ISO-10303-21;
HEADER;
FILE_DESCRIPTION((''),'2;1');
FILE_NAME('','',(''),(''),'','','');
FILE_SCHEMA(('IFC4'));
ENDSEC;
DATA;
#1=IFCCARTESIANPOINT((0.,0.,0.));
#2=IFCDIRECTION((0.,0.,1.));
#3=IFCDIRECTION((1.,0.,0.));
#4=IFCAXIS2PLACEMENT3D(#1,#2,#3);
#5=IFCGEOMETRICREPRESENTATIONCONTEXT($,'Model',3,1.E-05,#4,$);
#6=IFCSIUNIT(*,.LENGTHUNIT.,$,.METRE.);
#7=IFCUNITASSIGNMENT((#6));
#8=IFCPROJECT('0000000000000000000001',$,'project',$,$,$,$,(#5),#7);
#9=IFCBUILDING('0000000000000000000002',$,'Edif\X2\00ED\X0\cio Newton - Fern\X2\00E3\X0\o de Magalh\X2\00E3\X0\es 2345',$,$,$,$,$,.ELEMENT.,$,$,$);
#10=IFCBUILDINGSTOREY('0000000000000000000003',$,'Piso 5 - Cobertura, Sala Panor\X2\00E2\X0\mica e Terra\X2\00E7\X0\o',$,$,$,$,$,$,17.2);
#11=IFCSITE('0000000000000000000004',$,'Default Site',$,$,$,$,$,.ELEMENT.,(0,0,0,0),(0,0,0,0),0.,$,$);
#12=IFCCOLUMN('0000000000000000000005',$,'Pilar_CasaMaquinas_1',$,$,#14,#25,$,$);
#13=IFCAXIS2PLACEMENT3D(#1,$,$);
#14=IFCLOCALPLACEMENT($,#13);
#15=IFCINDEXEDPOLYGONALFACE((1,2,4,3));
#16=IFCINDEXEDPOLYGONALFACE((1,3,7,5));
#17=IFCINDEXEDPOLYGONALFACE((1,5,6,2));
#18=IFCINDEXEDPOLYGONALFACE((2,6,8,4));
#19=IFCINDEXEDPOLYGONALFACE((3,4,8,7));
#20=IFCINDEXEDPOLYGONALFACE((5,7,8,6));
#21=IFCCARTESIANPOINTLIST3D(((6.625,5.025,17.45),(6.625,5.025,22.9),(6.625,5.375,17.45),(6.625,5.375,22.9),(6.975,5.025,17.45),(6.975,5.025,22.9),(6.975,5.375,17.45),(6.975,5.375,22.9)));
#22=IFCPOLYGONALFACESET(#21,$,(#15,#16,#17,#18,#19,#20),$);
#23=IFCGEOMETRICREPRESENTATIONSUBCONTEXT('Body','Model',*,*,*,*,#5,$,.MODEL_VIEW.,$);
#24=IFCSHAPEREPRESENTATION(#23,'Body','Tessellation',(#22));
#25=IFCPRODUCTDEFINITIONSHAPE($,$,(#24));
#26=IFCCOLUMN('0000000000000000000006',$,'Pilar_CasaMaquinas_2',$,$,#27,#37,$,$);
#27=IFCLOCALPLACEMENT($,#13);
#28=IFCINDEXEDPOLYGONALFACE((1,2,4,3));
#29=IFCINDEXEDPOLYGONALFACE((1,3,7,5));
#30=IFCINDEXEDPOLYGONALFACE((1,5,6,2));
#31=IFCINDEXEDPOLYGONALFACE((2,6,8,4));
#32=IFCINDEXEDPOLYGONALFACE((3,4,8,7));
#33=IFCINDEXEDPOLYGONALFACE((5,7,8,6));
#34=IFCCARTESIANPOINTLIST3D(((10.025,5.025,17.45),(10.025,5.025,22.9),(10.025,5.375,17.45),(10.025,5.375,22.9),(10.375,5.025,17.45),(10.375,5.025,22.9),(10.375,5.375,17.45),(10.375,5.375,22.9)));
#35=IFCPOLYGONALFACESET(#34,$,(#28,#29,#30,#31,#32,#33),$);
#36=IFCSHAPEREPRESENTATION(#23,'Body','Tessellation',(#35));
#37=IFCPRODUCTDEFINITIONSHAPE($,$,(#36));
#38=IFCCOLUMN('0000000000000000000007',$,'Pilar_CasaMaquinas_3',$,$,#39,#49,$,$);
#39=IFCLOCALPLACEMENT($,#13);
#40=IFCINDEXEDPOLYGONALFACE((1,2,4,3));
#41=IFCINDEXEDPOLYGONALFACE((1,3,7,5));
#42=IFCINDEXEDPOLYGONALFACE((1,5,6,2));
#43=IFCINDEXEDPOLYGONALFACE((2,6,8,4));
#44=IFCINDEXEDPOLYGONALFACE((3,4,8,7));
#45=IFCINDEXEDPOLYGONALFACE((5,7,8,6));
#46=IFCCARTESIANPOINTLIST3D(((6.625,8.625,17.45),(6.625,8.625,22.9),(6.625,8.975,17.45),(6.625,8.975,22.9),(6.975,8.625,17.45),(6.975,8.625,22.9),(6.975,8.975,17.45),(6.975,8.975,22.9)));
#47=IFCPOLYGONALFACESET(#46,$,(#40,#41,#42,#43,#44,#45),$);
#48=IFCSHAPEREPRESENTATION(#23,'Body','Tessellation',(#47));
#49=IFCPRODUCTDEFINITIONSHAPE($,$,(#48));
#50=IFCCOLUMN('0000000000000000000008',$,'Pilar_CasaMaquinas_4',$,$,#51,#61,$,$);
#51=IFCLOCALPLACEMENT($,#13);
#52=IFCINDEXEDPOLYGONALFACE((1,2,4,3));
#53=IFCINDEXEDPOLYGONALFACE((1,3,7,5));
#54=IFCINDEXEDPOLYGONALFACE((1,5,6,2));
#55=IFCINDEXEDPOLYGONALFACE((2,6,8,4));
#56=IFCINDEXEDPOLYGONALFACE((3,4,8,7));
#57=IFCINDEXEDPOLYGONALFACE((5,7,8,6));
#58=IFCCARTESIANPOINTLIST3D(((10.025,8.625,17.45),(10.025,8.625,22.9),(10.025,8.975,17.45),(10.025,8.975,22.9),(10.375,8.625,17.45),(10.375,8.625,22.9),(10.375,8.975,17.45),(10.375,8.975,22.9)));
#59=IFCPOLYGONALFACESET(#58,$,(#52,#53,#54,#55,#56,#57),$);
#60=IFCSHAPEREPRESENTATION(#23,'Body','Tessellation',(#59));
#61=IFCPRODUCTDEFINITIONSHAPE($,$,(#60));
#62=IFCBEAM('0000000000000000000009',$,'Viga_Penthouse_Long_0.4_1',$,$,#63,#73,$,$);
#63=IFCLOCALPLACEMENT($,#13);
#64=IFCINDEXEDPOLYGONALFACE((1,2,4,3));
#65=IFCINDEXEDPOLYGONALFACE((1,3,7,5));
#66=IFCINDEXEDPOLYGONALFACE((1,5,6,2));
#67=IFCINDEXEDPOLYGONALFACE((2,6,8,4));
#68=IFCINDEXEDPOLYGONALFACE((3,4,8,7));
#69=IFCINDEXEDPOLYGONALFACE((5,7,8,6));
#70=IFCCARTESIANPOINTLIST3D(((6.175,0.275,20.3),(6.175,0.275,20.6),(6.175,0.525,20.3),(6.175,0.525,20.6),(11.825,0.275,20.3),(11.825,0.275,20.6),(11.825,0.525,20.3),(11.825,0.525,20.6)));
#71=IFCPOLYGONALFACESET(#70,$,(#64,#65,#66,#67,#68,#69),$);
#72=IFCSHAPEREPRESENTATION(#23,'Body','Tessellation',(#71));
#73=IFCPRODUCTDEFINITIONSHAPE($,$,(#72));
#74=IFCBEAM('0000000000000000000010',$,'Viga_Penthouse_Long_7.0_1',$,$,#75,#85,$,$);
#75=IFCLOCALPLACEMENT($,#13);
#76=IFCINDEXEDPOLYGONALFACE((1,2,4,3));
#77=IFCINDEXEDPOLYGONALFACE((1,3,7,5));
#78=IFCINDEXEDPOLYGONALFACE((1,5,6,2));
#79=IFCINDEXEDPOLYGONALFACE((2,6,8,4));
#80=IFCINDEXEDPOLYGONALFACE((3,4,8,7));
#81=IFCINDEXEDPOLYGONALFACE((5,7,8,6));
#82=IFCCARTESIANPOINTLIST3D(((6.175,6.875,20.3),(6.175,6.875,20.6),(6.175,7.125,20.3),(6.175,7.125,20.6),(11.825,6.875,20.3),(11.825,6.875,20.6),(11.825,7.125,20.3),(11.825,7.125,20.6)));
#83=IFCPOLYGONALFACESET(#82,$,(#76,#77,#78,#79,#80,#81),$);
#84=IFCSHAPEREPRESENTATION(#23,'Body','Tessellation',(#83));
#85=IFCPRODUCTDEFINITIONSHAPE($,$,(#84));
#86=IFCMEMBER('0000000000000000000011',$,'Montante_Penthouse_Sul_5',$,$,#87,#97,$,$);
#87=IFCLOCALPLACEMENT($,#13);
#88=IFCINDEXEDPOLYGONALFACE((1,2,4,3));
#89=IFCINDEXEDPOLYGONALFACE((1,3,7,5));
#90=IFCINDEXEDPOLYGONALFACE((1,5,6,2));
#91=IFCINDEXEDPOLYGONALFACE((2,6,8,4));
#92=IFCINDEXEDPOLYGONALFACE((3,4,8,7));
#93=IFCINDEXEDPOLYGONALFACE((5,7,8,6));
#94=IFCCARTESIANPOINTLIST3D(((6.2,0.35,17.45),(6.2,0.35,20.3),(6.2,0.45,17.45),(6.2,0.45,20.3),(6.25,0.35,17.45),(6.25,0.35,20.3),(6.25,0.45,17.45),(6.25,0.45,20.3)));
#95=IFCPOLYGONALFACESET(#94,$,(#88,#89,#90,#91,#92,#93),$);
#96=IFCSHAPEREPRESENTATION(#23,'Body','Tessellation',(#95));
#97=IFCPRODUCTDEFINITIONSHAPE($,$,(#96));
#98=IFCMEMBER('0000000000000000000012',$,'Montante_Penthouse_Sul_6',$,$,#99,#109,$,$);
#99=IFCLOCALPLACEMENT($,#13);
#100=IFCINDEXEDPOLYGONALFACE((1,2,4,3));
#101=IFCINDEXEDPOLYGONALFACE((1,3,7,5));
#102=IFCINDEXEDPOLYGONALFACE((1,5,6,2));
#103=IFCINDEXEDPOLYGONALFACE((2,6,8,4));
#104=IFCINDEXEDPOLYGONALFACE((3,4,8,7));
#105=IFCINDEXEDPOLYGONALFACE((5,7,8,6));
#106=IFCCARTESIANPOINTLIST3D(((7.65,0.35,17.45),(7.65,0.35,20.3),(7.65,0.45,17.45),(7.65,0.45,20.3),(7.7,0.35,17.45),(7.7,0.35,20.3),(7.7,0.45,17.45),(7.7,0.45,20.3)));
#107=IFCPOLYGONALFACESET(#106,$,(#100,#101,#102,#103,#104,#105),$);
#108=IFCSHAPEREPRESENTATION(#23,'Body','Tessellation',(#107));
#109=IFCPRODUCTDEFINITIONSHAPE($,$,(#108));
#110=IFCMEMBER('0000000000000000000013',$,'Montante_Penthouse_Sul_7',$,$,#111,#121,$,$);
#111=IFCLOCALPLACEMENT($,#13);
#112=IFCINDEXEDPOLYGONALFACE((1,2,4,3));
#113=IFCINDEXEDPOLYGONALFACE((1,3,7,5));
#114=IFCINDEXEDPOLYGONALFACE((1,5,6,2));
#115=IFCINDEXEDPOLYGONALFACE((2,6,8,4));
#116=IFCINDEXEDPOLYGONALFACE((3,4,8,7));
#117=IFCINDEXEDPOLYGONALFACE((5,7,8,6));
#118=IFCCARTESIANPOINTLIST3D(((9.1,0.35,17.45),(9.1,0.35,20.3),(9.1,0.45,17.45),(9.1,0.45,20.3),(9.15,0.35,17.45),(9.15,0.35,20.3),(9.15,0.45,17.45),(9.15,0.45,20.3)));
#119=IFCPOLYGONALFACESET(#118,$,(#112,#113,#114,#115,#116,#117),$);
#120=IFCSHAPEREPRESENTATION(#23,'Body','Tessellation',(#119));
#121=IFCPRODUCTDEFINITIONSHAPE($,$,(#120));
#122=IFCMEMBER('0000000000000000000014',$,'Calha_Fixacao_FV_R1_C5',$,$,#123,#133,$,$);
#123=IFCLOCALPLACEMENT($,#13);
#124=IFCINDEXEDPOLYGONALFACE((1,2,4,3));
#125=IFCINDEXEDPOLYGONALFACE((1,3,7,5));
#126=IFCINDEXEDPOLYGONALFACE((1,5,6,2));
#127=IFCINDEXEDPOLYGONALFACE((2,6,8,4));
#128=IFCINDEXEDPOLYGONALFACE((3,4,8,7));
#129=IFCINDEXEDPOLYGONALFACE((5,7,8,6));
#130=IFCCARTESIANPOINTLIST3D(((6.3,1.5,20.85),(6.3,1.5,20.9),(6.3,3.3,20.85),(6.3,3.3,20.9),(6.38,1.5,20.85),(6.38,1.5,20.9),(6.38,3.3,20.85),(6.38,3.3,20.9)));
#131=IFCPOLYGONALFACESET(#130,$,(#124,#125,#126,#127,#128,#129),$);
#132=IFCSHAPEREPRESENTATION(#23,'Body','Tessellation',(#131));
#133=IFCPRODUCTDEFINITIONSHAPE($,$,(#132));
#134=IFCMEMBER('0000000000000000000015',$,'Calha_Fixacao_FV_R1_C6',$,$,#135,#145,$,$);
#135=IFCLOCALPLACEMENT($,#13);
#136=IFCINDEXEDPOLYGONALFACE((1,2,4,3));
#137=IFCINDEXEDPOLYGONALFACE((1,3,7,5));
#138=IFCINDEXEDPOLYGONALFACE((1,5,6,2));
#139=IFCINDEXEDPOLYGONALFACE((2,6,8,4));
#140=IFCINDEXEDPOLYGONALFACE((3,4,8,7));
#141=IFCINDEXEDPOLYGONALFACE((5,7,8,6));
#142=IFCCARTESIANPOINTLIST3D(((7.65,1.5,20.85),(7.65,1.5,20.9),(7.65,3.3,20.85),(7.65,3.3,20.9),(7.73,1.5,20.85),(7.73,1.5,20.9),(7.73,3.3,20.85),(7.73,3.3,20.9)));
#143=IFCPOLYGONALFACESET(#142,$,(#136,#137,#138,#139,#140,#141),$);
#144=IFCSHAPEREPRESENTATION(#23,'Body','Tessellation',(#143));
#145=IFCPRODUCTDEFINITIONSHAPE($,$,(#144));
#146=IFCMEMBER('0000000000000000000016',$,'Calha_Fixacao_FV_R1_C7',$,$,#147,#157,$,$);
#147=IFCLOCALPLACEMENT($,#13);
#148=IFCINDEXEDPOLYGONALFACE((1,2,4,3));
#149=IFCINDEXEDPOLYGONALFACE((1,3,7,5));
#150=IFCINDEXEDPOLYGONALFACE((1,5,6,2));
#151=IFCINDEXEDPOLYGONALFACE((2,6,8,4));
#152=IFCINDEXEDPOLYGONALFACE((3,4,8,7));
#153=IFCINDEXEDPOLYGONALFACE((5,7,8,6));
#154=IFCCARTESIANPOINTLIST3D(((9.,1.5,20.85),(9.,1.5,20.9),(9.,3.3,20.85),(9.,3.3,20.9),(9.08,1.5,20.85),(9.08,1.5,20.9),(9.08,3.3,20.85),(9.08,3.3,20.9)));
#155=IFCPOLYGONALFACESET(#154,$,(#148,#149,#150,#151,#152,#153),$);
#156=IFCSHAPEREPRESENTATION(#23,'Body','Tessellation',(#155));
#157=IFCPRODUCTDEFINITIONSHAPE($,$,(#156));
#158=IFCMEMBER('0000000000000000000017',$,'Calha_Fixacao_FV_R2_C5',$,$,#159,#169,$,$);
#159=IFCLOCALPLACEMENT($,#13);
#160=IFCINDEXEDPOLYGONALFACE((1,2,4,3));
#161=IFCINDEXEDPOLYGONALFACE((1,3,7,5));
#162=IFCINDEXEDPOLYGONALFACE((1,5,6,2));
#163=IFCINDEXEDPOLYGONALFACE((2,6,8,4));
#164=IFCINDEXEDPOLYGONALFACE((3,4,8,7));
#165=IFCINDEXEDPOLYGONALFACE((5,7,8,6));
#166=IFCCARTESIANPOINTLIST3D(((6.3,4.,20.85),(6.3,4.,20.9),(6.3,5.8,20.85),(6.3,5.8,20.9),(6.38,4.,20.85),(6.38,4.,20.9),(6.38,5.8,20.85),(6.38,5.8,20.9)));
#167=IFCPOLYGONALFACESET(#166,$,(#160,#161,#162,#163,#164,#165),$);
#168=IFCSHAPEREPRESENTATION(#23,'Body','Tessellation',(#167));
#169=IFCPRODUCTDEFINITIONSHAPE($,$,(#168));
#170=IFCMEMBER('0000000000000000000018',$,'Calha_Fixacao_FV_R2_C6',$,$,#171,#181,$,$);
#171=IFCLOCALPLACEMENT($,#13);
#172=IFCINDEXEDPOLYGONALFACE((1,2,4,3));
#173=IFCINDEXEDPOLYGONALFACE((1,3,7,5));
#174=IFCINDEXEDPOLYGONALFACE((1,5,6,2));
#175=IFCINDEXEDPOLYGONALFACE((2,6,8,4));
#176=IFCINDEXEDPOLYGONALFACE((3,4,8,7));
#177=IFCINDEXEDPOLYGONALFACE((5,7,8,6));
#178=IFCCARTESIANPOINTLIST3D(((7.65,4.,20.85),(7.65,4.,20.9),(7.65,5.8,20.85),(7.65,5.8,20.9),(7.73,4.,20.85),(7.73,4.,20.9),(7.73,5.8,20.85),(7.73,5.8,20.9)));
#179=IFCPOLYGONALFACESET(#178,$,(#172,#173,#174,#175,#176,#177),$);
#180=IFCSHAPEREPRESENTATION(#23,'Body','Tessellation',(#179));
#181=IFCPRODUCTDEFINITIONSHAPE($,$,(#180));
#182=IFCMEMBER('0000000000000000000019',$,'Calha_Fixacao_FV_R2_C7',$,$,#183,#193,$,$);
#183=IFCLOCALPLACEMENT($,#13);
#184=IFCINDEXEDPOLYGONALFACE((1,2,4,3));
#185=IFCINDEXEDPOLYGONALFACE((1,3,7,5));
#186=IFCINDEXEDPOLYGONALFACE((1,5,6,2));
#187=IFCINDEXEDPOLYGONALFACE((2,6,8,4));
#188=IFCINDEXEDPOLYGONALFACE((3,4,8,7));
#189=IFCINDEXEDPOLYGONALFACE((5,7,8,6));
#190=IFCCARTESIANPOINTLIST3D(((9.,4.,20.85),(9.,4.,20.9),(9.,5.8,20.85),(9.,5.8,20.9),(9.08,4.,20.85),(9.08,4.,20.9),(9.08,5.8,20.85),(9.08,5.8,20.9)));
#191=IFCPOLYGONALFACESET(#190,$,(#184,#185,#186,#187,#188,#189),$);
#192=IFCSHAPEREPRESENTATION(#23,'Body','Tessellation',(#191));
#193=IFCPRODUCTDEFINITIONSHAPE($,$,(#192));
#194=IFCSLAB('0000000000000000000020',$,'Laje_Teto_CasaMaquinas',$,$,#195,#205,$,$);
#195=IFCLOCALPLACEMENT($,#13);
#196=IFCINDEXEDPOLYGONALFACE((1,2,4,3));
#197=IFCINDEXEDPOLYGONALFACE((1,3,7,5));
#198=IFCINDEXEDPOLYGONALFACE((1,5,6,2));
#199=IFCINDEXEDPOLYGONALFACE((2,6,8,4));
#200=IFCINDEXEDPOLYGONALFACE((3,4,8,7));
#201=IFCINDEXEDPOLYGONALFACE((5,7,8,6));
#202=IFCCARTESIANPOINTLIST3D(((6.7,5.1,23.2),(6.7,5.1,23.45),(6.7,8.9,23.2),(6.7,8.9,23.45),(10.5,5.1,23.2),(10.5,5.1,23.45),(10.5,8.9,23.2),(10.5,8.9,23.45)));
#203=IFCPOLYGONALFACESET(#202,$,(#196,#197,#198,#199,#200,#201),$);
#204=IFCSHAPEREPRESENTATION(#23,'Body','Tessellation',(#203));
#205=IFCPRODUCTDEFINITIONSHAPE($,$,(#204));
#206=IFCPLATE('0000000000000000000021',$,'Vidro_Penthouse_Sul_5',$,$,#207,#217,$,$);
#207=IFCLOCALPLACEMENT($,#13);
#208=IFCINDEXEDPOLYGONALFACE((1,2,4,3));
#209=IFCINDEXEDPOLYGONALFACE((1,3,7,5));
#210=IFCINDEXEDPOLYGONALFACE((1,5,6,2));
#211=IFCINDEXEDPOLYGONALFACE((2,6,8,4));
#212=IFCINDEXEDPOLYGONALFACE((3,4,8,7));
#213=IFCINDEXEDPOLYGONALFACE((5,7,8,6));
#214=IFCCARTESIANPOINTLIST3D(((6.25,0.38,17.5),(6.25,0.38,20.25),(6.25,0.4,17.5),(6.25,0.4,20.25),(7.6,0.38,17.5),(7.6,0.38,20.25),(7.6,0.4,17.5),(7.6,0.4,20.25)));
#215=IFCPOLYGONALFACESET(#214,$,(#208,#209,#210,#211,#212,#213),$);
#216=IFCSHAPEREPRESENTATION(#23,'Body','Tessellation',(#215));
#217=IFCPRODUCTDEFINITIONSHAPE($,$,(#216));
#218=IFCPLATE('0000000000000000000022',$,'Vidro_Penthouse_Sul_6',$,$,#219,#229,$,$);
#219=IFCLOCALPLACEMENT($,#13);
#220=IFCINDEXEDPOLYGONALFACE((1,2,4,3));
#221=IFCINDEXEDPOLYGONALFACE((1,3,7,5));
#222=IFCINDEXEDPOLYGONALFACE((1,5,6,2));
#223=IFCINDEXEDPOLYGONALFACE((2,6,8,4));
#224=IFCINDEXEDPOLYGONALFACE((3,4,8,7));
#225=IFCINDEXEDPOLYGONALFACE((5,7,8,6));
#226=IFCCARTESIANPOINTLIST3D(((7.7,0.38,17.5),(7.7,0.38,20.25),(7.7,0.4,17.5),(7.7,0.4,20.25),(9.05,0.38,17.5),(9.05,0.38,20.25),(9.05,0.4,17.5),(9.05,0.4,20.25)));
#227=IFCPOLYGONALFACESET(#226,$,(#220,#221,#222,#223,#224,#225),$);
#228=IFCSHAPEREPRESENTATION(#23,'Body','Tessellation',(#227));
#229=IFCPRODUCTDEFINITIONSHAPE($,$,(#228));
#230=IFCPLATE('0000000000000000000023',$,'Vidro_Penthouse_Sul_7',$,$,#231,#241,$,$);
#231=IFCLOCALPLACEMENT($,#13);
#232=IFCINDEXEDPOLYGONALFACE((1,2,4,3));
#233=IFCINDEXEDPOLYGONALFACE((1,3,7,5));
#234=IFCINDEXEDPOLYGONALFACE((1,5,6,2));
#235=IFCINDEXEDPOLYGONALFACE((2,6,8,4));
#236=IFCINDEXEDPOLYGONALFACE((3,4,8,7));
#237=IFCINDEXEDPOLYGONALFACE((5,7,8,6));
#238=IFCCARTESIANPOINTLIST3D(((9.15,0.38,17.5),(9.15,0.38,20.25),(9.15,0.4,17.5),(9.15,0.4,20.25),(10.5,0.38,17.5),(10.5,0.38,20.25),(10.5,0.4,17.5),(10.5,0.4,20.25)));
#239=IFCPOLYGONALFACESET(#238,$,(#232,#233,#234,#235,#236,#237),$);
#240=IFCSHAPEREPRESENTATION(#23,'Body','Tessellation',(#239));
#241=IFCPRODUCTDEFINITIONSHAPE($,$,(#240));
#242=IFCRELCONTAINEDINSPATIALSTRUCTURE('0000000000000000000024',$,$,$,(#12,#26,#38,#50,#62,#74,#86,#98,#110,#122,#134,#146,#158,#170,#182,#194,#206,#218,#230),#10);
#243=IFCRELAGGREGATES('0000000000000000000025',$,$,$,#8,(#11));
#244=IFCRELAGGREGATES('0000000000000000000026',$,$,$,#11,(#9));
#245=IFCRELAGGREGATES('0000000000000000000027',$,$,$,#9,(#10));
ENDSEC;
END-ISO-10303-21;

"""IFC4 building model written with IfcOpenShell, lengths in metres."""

from ifc_helpers import new_model, si_unit, frame, frame_2d, origin_with_axes, place, context, subcontext, project, spatial, rectangle, extrude, element, save


model = new_model("IFC4")

# Units and contexts
model_context = context("Model", 3, precision=1e-05, world=origin_with_axes())
body_context = subcontext(model_context, "Body", "Model", "MODEL_VIEW")
ifc_project = project(units=[si_unit("LENGTHUNIT", "METRE")], contexts=[model_context])

# Site, building, storey
site = spatial("IfcSite", under=ifc_project, Name="Default Site", CompositionType="ELEMENT", RefLatitude=(0, 0, 0, 0), RefLongitude=(0, 0, 0, 0), RefElevation=0.0)
building = spatial("IfcBuilding", under=site, Name="Edifício Newton - Fernão de Magalhães 2345", CompositionType="ELEMENT")
storey = spatial("IfcBuildingStorey", under=building, Name="Piso 5 - Cobertura, Sala Panorâmica e Terraço", Elevation=17.2)

# Columns
for number, where, z_axis, x_axis, name in (
    (1, (6.625, 5.025, 17.45), (0.0, 0.0, 1.0), (1.0, 0.0, 0.0), "Pilar_CasaMaquinas_1"),
    (2, (10.025, 5.025, 17.45), (0.0, 0.0, 1.0), (1.0, 0.0, 0.0), "Pilar_CasaMaquinas_2"),
    (3, (6.625, 8.625, 17.45), (0.0, 0.0, 1.0), (1.0, 0.0, 0.0), "Pilar_CasaMaquinas_3"),
    (4, (10.025, 8.625, 17.45), (0.0, 0.0, 1.0), (1.0, 0.0, 0.0), "Pilar_CasaMaquinas_4"),
):
    element("IfcColumn", number, at=place(None, frame(where, z_axis=z_axis, x_axis=x_axis)), inside=storey, Name=name, context=body_context, shape_type="SweptSolid", body=[
        extrude(rectangle(XDim=0.35, YDim=0.35, at=frame_2d((0.175, 0.175))), origin_with_axes(), (0.0, 0.0, 1.0), 5.45),
    ])

# Beams
for number, where, z_axis, x_axis, name in (
    (5, (6.175, 0.275, 20.3), (0.0, 0.0, 1.0), (1.0, 0.0, 0.0), "Viga_Penthouse_Long_0.4_1"),
    (6, (6.175, 6.875, 20.3), (0.0, 0.0, 1.0), (1.0, 0.0, 0.0), "Viga_Penthouse_Long_7.0_1"),
):
    element("IfcBeam", number, at=place(None, frame(where, z_axis=z_axis, x_axis=x_axis)), inside=storey, Name=name, context=body_context, shape_type="SweptSolid", body=[
        extrude(rectangle(XDim=5.65, YDim=0.25, at=frame_2d((2.825, 0.125))), origin_with_axes(), (0.0, 0.0, 1.0), 0.3),
    ])

# Members
for number, where, z_axis, x_axis, name in (
    (7, (6.2, 0.35, 17.45), (0.0, 0.0, 1.0), (1.0, 0.0, 0.0), "Montante_Penthouse_Sul_5"),
    (8, (7.65, 0.35, 17.45), (0.0, 0.0, 1.0), (1.0, 0.0, 0.0), "Montante_Penthouse_Sul_6"),
    (9, (9.1, 0.35, 17.45), (0.0, 0.0, 1.0), (1.0, 0.0, 0.0), "Montante_Penthouse_Sul_7"),
):
    element("IfcMember", number, at=place(None, frame(where, z_axis=z_axis, x_axis=x_axis)), inside=storey, Name=name, context=body_context, shape_type="SweptSolid", body=[
        extrude(rectangle(XDim=0.05, YDim=0.1, at=frame_2d((0.025, 0.05))), origin_with_axes(), (0.0, 0.0, 1.0), 2.85),
    ])
for number, where, z_axis, x_axis, name in (
    (10, (6.3, 1.5, 20.85), (0.0, 0.0, 1.0), (1.0, 0.0, 0.0), "Calha_Fixacao_FV_R1_C5"),
    (11, (7.65, 1.5, 20.85), (0.0, 0.0, 1.0), (1.0, 0.0, 0.0), "Calha_Fixacao_FV_R1_C6"),
    (12, (9.0, 1.5, 20.85), (0.0, 0.0, 1.0), (1.0, 0.0, 0.0), "Calha_Fixacao_FV_R1_C7"),
    (13, (6.3, 4.0, 20.85), (0.0, 0.0, 1.0), (1.0, 0.0, 0.0), "Calha_Fixacao_FV_R2_C5"),
    (14, (7.65, 4.0, 20.85), (0.0, 0.0, 1.0), (1.0, 0.0, 0.0), "Calha_Fixacao_FV_R2_C6"),
    (15, (9.0, 4.0, 20.85), (0.0, 0.0, 1.0), (1.0, 0.0, 0.0), "Calha_Fixacao_FV_R2_C7"),
):
    element("IfcMember", number, at=place(None, frame(where, z_axis=z_axis, x_axis=x_axis)), inside=storey, Name=name, context=body_context, shape_type="SweptSolid", body=[
        extrude(rectangle(XDim=0.08, YDim=1.8, at=frame_2d((0.04, 0.9))), origin_with_axes(), (0.0, 0.0, 1.0), 0.05),
    ])

# Slab
slab_placement = place(None, frame((6.7, 5.1, 23.2), z_axis=(0.0, 0.0, 1.0), x_axis=(1.0, 0.0, 0.0)))
element("IfcSlab", 16, at=slab_placement, inside=storey, Name="Laje_Teto_CasaMaquinas", context=body_context, shape_type="SweptSolid", body=[
    extrude(rectangle(XDim=3.8, YDim=3.8, at=frame_2d((1.9, 1.9))), origin_with_axes(), (0.0, 0.0, 1.0), 0.25),
])

# Plates
for number, where, z_axis, x_axis, name in (
    (17, (6.25, 0.38, 17.5), (0.0, 0.0, 1.0), (1.0, 0.0, 0.0), "Vidro_Penthouse_Sul_5"),
    (18, (7.7, 0.38, 17.5), (0.0, 0.0, 1.0), (1.0, 0.0, 0.0), "Vidro_Penthouse_Sul_6"),
    (19, (9.15, 0.38, 17.5), (0.0, 0.0, 1.0), (1.0, 0.0, 0.0), "Vidro_Penthouse_Sul_7"),
):
    element("IfcPlate", number, at=place(None, frame(where, z_axis=z_axis, x_axis=x_axis)), inside=storey, Name=name, context=body_context, shape_type="SweptSolid", body=[
        extrude(rectangle(XDim=1.35, YDim=0.02, at=frame_2d((0.675, 0.01))), origin_with_axes(), (0.0, 0.0, 1.0), 2.75),
    ])

save(model, "model.ifc")
